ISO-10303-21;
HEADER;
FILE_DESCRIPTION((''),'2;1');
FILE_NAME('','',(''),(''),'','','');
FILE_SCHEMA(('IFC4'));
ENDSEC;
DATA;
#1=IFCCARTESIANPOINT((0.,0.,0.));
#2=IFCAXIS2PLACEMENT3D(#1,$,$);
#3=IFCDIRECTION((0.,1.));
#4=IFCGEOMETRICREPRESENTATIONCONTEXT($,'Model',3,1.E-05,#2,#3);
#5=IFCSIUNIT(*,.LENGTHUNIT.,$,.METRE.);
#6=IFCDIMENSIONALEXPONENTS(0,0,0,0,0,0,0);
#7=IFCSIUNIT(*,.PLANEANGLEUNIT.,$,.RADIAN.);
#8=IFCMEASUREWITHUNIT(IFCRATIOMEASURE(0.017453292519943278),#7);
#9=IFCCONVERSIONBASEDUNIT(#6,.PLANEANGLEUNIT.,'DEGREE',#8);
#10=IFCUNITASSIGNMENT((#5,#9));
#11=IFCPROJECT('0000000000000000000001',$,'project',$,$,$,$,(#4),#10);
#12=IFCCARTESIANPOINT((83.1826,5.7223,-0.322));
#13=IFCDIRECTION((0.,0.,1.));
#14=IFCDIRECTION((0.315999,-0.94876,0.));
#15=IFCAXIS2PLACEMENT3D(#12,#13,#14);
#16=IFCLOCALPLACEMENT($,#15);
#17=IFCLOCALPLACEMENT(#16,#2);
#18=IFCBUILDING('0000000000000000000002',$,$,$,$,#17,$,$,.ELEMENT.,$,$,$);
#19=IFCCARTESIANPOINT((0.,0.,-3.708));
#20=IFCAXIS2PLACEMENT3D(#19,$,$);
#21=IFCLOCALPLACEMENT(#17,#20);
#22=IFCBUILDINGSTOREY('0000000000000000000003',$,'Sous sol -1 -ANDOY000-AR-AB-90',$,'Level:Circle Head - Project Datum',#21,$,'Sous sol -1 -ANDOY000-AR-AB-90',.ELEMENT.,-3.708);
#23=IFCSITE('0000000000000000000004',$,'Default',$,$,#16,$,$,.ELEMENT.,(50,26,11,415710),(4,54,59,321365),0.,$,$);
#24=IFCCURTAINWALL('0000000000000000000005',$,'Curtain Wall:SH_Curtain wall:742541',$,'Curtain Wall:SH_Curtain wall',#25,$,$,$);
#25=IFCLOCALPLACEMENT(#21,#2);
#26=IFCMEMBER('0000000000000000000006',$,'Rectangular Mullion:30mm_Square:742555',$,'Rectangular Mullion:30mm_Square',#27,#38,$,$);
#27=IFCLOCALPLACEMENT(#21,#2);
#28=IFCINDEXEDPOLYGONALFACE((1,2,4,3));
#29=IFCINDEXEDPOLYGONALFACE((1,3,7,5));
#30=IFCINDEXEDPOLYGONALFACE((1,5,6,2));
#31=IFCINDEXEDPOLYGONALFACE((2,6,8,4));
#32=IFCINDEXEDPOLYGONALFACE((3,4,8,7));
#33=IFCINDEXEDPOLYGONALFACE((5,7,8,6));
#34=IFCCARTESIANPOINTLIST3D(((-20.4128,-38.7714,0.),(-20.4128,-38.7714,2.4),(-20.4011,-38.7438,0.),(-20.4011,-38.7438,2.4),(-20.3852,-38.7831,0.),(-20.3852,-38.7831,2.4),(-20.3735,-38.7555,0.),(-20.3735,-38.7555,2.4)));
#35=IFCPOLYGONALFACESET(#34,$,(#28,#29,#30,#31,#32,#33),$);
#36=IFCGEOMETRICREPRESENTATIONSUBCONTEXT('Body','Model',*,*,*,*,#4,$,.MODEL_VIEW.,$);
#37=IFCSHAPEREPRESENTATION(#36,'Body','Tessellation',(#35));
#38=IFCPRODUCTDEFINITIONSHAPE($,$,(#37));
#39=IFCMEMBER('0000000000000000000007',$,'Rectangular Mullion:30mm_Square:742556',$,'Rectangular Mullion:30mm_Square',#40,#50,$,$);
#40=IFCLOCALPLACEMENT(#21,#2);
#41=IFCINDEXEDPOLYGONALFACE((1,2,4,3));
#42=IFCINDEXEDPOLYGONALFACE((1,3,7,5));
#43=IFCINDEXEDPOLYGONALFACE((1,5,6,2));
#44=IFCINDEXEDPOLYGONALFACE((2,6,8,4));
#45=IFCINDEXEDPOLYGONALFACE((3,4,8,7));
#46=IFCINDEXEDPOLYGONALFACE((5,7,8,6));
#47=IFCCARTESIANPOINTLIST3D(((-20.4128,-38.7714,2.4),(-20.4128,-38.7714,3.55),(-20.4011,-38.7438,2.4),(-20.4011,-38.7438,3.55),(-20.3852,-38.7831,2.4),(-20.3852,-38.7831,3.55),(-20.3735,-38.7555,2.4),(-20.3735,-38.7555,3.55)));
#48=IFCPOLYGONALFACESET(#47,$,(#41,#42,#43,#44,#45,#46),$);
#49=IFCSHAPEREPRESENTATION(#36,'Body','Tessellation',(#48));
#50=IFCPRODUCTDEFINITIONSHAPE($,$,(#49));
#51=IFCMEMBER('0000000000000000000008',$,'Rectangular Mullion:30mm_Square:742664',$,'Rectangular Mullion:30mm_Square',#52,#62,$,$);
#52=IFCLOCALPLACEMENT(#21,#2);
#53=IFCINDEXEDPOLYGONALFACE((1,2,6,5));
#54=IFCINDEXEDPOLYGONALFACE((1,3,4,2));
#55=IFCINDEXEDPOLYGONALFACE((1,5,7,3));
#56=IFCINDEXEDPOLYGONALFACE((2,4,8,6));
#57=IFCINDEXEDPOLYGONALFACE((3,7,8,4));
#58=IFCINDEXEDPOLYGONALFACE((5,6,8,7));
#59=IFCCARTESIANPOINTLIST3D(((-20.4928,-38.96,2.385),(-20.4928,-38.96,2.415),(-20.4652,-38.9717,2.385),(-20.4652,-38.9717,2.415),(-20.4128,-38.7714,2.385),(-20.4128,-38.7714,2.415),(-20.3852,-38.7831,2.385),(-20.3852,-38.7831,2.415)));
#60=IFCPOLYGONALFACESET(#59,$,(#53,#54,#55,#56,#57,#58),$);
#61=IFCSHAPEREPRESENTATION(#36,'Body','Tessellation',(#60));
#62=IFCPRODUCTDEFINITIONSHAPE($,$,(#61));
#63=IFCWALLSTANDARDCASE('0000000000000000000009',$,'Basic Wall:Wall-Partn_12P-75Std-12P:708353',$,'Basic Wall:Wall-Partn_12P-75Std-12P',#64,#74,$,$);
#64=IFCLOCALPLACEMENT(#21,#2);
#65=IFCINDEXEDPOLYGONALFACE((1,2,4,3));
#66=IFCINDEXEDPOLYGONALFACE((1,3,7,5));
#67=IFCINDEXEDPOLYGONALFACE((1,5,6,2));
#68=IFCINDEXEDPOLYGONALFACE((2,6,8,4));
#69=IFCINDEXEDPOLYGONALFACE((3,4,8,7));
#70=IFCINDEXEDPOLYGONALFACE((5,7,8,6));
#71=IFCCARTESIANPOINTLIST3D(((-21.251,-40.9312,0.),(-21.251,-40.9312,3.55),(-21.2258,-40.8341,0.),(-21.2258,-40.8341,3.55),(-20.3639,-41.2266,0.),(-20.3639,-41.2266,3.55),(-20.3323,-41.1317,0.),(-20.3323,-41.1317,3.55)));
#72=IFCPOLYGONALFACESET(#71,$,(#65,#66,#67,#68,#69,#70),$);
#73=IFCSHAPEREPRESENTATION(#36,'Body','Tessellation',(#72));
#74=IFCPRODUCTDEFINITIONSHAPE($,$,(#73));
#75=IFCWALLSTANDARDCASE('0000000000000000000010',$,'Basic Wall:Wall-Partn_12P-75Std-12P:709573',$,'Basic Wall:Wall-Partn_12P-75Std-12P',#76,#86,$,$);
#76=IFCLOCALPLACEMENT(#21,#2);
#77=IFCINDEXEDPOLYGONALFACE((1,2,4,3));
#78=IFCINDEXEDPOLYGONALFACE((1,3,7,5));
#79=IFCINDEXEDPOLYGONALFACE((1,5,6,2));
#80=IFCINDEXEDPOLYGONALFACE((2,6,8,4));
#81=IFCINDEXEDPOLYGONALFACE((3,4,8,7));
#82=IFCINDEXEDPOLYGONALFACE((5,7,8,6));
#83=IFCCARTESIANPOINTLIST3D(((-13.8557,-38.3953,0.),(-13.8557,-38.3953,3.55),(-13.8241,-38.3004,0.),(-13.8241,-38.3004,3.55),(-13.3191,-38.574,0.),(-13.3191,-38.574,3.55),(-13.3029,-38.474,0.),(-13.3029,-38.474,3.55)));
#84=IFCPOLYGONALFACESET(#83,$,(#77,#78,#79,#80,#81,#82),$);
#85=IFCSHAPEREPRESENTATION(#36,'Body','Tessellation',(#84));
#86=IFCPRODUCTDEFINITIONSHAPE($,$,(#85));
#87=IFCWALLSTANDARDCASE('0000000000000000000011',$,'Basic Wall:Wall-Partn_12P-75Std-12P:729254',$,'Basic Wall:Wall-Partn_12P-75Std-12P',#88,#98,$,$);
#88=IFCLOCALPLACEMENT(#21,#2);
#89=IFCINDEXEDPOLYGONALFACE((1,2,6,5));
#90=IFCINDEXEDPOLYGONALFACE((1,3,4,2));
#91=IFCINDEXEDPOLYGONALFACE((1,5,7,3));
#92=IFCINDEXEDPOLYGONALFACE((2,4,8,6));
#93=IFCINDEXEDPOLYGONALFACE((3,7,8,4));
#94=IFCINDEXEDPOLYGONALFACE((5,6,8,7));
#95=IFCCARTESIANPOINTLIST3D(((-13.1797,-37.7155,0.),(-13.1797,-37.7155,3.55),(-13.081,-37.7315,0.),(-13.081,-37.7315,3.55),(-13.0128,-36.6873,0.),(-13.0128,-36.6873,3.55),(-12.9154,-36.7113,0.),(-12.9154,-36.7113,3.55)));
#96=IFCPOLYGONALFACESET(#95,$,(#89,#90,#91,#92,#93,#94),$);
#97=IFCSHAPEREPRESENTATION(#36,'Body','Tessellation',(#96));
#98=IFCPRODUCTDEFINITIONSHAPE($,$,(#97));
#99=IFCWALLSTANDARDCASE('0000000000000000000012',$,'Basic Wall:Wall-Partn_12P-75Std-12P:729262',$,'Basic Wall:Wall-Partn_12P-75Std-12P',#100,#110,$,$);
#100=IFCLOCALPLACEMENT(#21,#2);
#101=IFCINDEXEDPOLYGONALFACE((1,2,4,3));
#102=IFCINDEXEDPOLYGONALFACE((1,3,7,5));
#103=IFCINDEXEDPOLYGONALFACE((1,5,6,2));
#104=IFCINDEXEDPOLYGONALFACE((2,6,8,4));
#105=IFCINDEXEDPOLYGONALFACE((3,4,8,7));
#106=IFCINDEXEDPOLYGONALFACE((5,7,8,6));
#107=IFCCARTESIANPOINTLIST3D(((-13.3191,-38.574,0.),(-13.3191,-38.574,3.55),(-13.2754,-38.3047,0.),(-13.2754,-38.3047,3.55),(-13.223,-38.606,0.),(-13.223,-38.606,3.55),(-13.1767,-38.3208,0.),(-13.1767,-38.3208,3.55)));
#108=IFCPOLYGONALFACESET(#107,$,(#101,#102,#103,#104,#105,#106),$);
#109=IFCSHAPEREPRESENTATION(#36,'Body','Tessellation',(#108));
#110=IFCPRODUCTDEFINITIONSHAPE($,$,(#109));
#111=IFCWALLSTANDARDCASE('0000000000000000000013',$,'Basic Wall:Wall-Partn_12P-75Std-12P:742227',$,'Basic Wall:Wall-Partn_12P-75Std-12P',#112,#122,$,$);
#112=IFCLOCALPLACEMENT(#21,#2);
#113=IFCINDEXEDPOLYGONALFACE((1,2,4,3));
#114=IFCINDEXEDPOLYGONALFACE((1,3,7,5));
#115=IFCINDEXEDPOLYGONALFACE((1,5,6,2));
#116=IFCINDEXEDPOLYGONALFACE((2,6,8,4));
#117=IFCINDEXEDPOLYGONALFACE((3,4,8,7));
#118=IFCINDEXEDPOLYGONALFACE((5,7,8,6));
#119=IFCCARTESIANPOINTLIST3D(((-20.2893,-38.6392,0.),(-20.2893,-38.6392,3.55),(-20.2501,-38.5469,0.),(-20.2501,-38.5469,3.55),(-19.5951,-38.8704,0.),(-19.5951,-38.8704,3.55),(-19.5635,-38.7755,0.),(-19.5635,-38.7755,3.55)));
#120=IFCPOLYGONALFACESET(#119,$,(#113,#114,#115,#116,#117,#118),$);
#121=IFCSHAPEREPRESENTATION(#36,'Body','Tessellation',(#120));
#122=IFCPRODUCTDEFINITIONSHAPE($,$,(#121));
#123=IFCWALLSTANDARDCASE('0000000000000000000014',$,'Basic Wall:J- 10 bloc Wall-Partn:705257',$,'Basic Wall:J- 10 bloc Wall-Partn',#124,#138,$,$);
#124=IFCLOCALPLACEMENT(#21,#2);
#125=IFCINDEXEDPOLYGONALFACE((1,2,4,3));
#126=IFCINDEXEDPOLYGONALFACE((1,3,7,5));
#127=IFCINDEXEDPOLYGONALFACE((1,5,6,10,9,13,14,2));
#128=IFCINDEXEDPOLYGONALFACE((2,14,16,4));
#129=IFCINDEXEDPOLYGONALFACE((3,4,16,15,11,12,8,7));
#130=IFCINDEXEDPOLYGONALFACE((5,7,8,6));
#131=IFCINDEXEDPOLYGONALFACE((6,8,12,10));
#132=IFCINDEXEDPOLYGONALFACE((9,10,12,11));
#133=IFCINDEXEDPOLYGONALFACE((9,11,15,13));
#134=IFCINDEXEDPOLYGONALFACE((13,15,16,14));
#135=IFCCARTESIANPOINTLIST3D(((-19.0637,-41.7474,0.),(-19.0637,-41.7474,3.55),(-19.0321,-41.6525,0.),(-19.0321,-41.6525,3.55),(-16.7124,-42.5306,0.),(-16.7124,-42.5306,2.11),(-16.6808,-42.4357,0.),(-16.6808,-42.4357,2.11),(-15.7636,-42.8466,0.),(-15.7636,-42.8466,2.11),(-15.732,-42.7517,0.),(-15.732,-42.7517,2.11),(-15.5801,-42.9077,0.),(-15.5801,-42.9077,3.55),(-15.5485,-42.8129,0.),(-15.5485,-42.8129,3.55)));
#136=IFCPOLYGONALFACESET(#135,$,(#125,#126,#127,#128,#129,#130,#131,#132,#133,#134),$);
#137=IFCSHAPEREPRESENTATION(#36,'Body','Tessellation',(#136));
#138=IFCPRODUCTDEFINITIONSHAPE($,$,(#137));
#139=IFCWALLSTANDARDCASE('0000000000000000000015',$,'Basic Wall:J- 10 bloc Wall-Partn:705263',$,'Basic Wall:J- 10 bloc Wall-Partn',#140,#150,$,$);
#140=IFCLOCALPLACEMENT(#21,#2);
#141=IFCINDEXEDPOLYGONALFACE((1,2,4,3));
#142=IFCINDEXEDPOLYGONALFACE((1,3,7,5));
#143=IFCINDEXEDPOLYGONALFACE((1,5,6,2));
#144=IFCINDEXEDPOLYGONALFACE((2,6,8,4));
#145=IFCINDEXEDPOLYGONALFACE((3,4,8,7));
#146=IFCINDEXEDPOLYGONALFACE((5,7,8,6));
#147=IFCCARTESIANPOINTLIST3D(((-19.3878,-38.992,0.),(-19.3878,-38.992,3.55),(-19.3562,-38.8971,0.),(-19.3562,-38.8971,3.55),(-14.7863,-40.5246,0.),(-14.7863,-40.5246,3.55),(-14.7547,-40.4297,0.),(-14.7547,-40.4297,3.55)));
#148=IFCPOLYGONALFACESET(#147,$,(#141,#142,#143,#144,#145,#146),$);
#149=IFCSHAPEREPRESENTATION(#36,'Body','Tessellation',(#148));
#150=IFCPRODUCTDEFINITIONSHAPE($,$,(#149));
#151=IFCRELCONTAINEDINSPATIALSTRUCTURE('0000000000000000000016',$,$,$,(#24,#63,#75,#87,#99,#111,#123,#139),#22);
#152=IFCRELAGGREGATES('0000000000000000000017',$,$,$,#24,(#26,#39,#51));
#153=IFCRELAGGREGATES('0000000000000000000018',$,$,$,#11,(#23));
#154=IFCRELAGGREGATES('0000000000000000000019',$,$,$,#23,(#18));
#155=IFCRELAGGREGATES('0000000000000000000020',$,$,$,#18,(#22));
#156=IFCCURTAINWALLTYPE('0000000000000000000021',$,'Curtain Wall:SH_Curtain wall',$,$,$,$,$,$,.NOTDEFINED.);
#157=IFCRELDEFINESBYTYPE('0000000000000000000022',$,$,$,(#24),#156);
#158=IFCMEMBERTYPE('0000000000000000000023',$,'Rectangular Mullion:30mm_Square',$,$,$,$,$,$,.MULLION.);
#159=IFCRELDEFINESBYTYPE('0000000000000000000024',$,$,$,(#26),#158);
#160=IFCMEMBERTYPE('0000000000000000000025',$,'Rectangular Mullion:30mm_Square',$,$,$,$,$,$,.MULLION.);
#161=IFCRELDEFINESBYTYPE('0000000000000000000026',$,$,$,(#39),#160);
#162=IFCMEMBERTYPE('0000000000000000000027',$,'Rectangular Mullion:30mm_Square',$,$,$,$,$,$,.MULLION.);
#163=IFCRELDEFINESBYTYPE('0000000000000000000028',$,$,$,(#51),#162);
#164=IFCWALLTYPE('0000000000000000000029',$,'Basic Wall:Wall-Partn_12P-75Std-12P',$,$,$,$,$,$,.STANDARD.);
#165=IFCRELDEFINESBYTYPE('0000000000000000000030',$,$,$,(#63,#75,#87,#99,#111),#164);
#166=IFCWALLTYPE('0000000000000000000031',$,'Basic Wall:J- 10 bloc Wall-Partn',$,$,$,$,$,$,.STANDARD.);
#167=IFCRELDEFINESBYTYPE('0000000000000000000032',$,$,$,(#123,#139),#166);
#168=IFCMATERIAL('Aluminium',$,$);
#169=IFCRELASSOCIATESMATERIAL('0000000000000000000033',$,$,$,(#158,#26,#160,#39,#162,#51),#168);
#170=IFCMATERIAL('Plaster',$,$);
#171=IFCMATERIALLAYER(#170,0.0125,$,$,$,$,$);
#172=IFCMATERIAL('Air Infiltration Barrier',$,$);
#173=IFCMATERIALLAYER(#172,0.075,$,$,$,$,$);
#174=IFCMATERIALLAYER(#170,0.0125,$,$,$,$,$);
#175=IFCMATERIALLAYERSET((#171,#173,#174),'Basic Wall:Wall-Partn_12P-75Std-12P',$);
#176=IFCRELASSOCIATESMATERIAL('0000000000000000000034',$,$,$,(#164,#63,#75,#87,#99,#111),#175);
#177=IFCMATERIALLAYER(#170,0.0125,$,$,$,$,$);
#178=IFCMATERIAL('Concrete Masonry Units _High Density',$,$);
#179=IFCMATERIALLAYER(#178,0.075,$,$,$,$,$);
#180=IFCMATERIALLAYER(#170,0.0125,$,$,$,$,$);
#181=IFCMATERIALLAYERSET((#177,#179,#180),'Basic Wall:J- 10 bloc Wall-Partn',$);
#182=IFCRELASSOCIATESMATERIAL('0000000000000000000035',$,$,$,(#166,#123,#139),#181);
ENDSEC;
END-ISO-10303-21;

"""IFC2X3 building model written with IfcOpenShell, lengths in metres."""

from ifc_helpers import new_model, entity, si_unit, converted_unit, direction, frame, frame_2d, origin, origin_2d_with_axis, place, context, subcontext, project, spatial, polyline, rectangle, outline, extrude, clip, bounded_halfspace, source, transform, mapped, material, layer, layer_set, layer_usage, type_object, type_shapes, element, aggregate, save


model = new_model("IFC2X3")

# Units and contexts
model_context = context("Model", 3, precision=1e-05, world=origin(), true_north=direction((0.0, 1.0)))
body_context = subcontext(model_context, "Body", "Model", "MODEL_VIEW")
ifc_project = project(units=[si_unit("LENGTHUNIT", "METRE"), converted_unit("PLANEANGLEUNIT", "DEGREE", entity("IfcRatioMeasure", 0.017453292519943278), si_unit("PLANEANGLEUNIT", "RADIAN"), dimensions=[0, 0, 0, 0, 0, 0, 0])], contexts=[model_context])

# Site, building, storey
site_placement = place(None, frame((83.1826, 5.7223, -0.322), z_axis=(0.0, 0.0, 1.0), x_axis=(0.315999, -0.94876, 0.0)))
site = spatial("IfcSite", under=ifc_project, at=site_placement, Name="Default", CompositionType="ELEMENT", RefLatitude=(50, 26, 11, 415710), RefLongitude=(4, 54, 59, 321365), RefElevation=0.0)
building_placement = place(site_placement, origin())
building = spatial("IfcBuilding", under=site, at=building_placement, CompositionType="ELEMENT")
storey_placement = place(building_placement, frame((0.0, 0.0, -3.708)))
storey = spatial("IfcBuildingStorey", under=building, at=storey_placement, Name="Sous sol -1 -ANDOY000-AR-AB-90", ObjectType="Level:Circle Head - Project Datum", LongName="Sous sol -1 -ANDOY000-AR-AB-90", CompositionType="ELEMENT", Elevation=-3.708)

# Curtain wall, members
curtain_wall_type = type_object("IfcCurtainWallType", Name="Curtain Wall:SH_Curtain wall", PredefinedType="NOTDEFINED")
curtain_wall_placement = place(storey_placement, frame((0.0, 0.0, 3.708)))
curtain_wall = element("IfcCurtainWall", 1, at=curtain_wall_placement, inside=storey, type_object=curtain_wall_type, Name="Curtain Wall:SH_Curtain wall:742541", ObjectType="Curtain Wall:SH_Curtain wall")
ifc_material_1 = material(Name="Aluminium")
member_type_1 = type_object("IfcMemberType", Name="Rectangular Mullion:30mm_Square", PredefinedType="MULLION", material=ifc_material_1)
shared_shape_1 = source(origin(), body_context, "Body", "SweptSolid", [
    extrude(rectangle(XDim=0.03, YDim=0.03, at=origin_2d_with_axis()), frame((-0.015, 0.0, -2.4), z_axis=(0.0, 0.0, 1.0), x_axis=(0.0, -1.0, 0.0)), (0.0, 0.0, 1.0), 2.4),
])
type_shapes(member_type_1, [shared_shape_1])
member_1_placement = place(curtain_wall_placement, frame((-20.3873, -38.7497, -3.708), z_axis=(0.0, 0.0, -1.0), x_axis=(0.390731, 0.920505, 0.0)))
member_1 = element("IfcMember", 2, at=member_1_placement, type_object=member_type_1, material=ifc_material_1, Name="Rectangular Mullion:30mm_Square:742555", ObjectType="Rectangular Mullion:30mm_Square", context=body_context, shape_type="MappedRepresentation", body=[
    mapped(shared_shape_1, transform((0.0, 0.0, 0.0), scale=1.0)),
])
member_type_2 = type_object("IfcMemberType", Name="Rectangular Mullion:30mm_Square", PredefinedType="MULLION", material=ifc_material_1)
shared_shape_2 = source(origin(), body_context, "Body", "SweptSolid", [
    extrude(rectangle(XDim=0.03, YDim=0.03, at=origin_2d_with_axis()), frame((-0.015, 0.0, -1.15), z_axis=(0.0, 0.0, 1.0), x_axis=(0.0, -1.0, 0.0)), (0.0, 0.0, 1.0), 1.15),
])
type_shapes(member_type_2, [shared_shape_2])
member_2_placement = place(curtain_wall_placement, frame((-20.3873, -38.7497, -1.308), z_axis=(0.0, 0.0, -1.0), x_axis=(0.390731, 0.920505, 0.0)))
member_2 = element("IfcMember", 3, at=member_2_placement, type_object=member_type_2, material=ifc_material_1, Name="Rectangular Mullion:30mm_Square:742556", ObjectType="Rectangular Mullion:30mm_Square", context=body_context, shape_type="MappedRepresentation", body=[
    mapped(shared_shape_2, transform((0.0, 0.0, 0.0), scale=1.0)),
])
member_type_3 = type_object("IfcMemberType", Name="Rectangular Mullion:30mm_Square", PredefinedType="MULLION", material=ifc_material_1)
shared_shape_3 = source(origin(), body_context, "Body", "SweptSolid", [
    extrude(rectangle(XDim=0.03, YDim=0.03, at=origin_2d_with_axis()), frame((0.0, 0.0, -0.2048), z_axis=(0.0, 0.0, 1.0), x_axis=(0.0, -1.0, 0.0)), (0.0, 0.0, 1.0), 0.2048),
])
type_shapes(member_type_3, [shared_shape_3])
member_3_placement = place(curtain_wall_placement, frame((-20.399, -38.7773, -1.308), z_axis=(0.390731, 0.920505, 0.0), x_axis=(0.0, 0.0, 1.0)))
member_3 = element("IfcMember", 4, at=member_3_placement, type_object=member_type_3, material=ifc_material_1, Name="Rectangular Mullion:30mm_Square:742664", ObjectType="Rectangular Mullion:30mm_Square", context=body_context, shape_type="MappedRepresentation", body=[
    mapped(shared_shape_3, transform((0.0, 0.0, 0.0), scale=1.0)),
])
aggregate(curtain_wall, [member_1, member_2, member_3])

# Walls
ifc_material_2 = material(Name="Plaster")
ifc_layer_1 = layer(ifc_material_2, 0.0125)
ifc_material_3 = material(Name="Air Infiltration Barrier")
ifc_layer_2 = layer(ifc_material_3, 0.075)
ifc_layer_3 = layer(ifc_material_2, 0.0125)
ifc_layer_set_1 = layer_set([ifc_layer_1, ifc_layer_2, ifc_layer_3], Name="Basic Wall:Wall-Partn_12P-75Std-12P")
ifc_layer_usage_1 = layer_usage(ifc_layer_set_1, "AXIS2", "NEGATIVE", 0.05)
wall_type_1 = type_object("IfcWallType", Name="Basic Wall:Wall-Partn_12P-75Std-12P", PredefinedType="STANDARD", material=ifc_layer_set_1)
wall_1_placement = place(storey_placement, frame((-20.3481, -41.1792, 0.0), z_axis=(0.0, 0.0, 1.0), x_axis=(-0.948759, 0.316, 0.0)))
element("IfcWallStandardCase", 5, at=wall_1_placement, inside=storey, type_object=wall_type_1, material=ifc_layer_usage_1, Name="Basic Wall:Wall-Partn_12P-75Std-12P:708353", ObjectType="Basic Wall:Wall-Partn_12P-75Std-12P", context=body_context, shape_type="Clipping", body=[
    clip(extrude(outline(polyline([(0.9418, -0.05), (0.9349, 0.05), (0.0, 0.05), (0.0, -0.05), (0.9343, -0.05), (0.9418, -0.05)])), origin(), (0.0, 0.0, 1.0), 3.55), bounded_halfspace(frame((0.0, -0.05, 3.55), z_axis=(0.0, 0.0, -1.0), x_axis=(-1.0, 0.0, 0.0)), True, frame((0.0, -0.05, 3.55)), polyline([(0.0, 0.0), (0.9343, 0.0), (0.9418, 0.0), (0.9349, 0.1), (0.0, 0.1), (0.0, 0.0)]))),
])
wall_2_placement = place(storey_placement, frame((-13.8399, -38.3479, 0.0), z_axis=(0.0, 0.0, 1.0), x_axis=(0.948759, -0.316, 0.0)))
element("IfcWallStandardCase", 6, at=wall_2_placement, inside=storey, type_object=wall_type_1, material=ifc_layer_usage_1, Name="Basic Wall:Wall-Partn_12P-75Std-12P:709573", ObjectType="Basic Wall:Wall-Partn_12P-75Std-12P", context=body_context, shape_type="Clipping", body=[
    clip(extrude(outline(polyline([(0.5655, -0.05), (0.5493, 0.05), (0.0, 0.05), (0.0, -0.05), (0.5655, -0.05)])), origin(), (0.0, 0.0, 1.0), 3.55), bounded_halfspace(frame((0.0, -0.05, 3.55), z_axis=(0.0, 0.0, -1.0), x_axis=(1.0, 0.0, 0.0)), True, frame((0.0, -0.05, 3.55)), polyline([(0.0, 0.0), (0.5655, 0.0), (0.5493, 0.1), (0.0, 0.1), (0.0, 0.0)]))),
])
wall_3_placement = place(storey_placement, frame((-13.1304, -37.7235, 0.0), z_axis=(0.0, 0.0, 1.0), x_axis=(0.160241, 0.987078, 0.0)))
element("IfcWallStandardCase", 7, at=wall_3_placement, inside=storey, type_object=wall_type_1, material=ifc_layer_usage_1, Name="Basic Wall:Wall-Partn_12P-75Std-12P:729254", ObjectType="Basic Wall:Wall-Partn_12P-75Std-12P", context=body_context, shape_type="Clipping", body=[
    clip(extrude(outline(polyline([(1.0336, -0.05), (1.0416, 0.05), (0.0, 0.05), (0.0, -0.05), (1.0336, -0.05)])), origin(), (0.0, 0.0, 1.0), 3.55), bounded_halfspace(frame((0.0, -0.05, 3.55), z_axis=(0.0, 0.0, -1.0), x_axis=(-0.159887, -0.987135, 0.0)), True, frame((0.0, -0.05, 3.55)), polyline([(0.0, 0.0), (1.0336, 0.0), (1.0416, 0.1), (0.0, 0.1), (0.0, 0.0)]))),
])
wall_4_placement = place(storey_placement, frame((-13.2724, -38.598, 0.0), z_axis=(0.0, 0.0, 1.0), x_axis=(0.160241, 0.987078, 0.0)))
element("IfcWallStandardCase", 8, at=wall_4_placement, inside=storey, type_object=wall_type_1, material=ifc_layer_usage_1, Name="Basic Wall:Wall-Partn_12P-75Std-12P:729262", ObjectType="Basic Wall:Wall-Partn_12P-75Std-12P", context=body_context, shape_type="Clipping", body=[
    clip(extrude(outline(polyline([(0.289, -0.05), (0.289, 0.05), (0.1175, 0.05), (0.0162, 0.05), (0.0, -0.05), (0.289, -0.05)])), origin(), (0.0, 0.0, 1.0), 3.55), bounded_halfspace(frame((0.0, -0.05, 3.55), z_axis=(0.0, 0.0, -1.0), x_axis=(-0.159887, -0.987135, 0.0)), True, frame((0.0, -0.05, 3.55)), polyline([(0.0, 0.0), (0.289, 0.0), (0.289, 0.1), (0.1175, 0.1), (0.0162, 0.1), (0.0, 0.0)]))),
])
wall_5_placement = place(storey_placement, frame((-19.5793, -38.823, 0.0), z_axis=(0.0, 0.0, 1.0), x_axis=(-0.948772, 0.315961, 0.0)))
element("IfcWallStandardCase", 9, at=wall_5_placement, inside=storey, type_object=wall_type_1, material=ifc_layer_usage_1, Name="Basic Wall:Wall-Partn_12P-75Std-12P:742227", ObjectType="Basic Wall:Wall-Partn_12P-75Std-12P", context=body_context, shape_type="Clipping", body=[
    clip(extrude(outline(polyline([(0.7237, -0.05), (0.7317, 0.05), (0.7287, 0.05), (0.0, 0.05), (0.0, -0.05), (0.7237, -0.05)])), origin(), (0.0, 0.0, 1.0), 3.55), bounded_halfspace(frame((0.0, -0.05, 3.55), z_axis=(0.0, 0.0, -1.0), x_axis=(-1.0, 0.000041, 0.0)), True, frame((0.0, -0.05, 3.55)), polyline([(0.0, 0.0), (0.7237, 0.0), (0.7317, 0.1), (0.7287, 0.1), (0.0, 0.1), (0.0, 0.0)]))),
])

# Wall, opening
ifc_layer_4 = layer(ifc_material_2, 0.0125)
ifc_material_4 = material(Name="Concrete Masonry Units _High Density")
ifc_layer_5 = layer(ifc_material_4, 0.075)
ifc_layer_6 = layer(ifc_material_2, 0.0125)
ifc_layer_set_2 = layer_set([ifc_layer_4, ifc_layer_5, ifc_layer_6], Name="Basic Wall:J- 10 bloc Wall-Partn")
ifc_layer_usage_2 = layer_usage(ifc_layer_set_2, "AXIS2", "NEGATIVE", 0.05)
wall_type_2 = type_object("IfcWallType", Name="Basic Wall:J- 10 bloc Wall-Partn", PredefinedType="STANDARD", material=ifc_layer_set_2)
wall_6_placement = place(storey_placement, frame((-15.5643, -42.8603, 0.0), z_axis=(0.0, 0.0, 1.0), x_axis=(-0.948755, 0.316014, 0.0)))
wall_6 = element("IfcWallStandardCase", 10, at=wall_6_placement, inside=storey, type_object=wall_type_2, material=ifc_layer_usage_2, Name="Basic Wall:J- 10 bloc Wall-Partn:705257", ObjectType="Basic Wall:J- 10 bloc Wall-Partn", context=body_context, shape_type="Clipping", body=[
    clip(extrude(rectangle(XDim=3.6717, YDim=0.1, at=frame_2d((1.8359, 0.0), x_axis=(1.0, 0.0))), origin(), (0.0, 0.0, 1.0), 3.55), bounded_halfspace(frame((0.0, -0.05, 3.55), z_axis=(0.0, 0.0, -1.0), x_axis=(-1.0, -0.000014, 0.0)), True, frame((0.0, -0.05, 3.55)), polyline([(0.0, 0.0), (3.6717, 0.0), (3.6717, 0.1), (1.2051, 0.1), (1.1051, 0.1), (0.0, 0.1), (0.0, 0.0)]))),
])
opening_placement = place(wall_6_placement, frame((1.1934, 0.05, 0.0)))
element("IfcOpeningElement", 11, at=opening_placement, cuts=wall_6, ObjectType="Opening", context=body_context, shape_type="SweptSolid", body=[
    extrude(rectangle(XDim=2.11, YDim=1.0, at=frame_2d((1.055, 0.5), x_axis=(1.0, 0.0))), frame((0.0, 0.0, 0.0), z_axis=(0.0, -1.0, 0.0), x_axis=(0.0, 0.0, 1.0)), (0.0, 0.0, 1.0), 0.1),
])

# Wall
wall_7_placement = place(storey_placement, frame((-19.372, -38.9446, 0.0), z_axis=(0.0, 0.0, 1.0), x_axis=(0.948759, -0.316, 0.0)))
element("IfcWallStandardCase", 12, at=wall_7_placement, inside=storey, type_object=wall_type_2, material=ifc_layer_usage_2, Name="Basic Wall:J- 10 bloc Wall-Partn:705263", ObjectType="Basic Wall:J- 10 bloc Wall-Partn", context=body_context, shape_type="Clipping", body=[
    clip(extrude(rectangle(XDim=4.85, YDim=0.1, at=frame_2d((2.425, 0.0), x_axis=(-1.0, 0.0))), origin(), (0.0, 0.0, 1.0), 3.55), bounded_halfspace(frame((0.0, -0.05, 3.55), z_axis=(0.0, 0.0, -1.0), x_axis=(1.0, 0.0, 0.0)), True, frame((0.0, -0.05, 3.55)), polyline([(0.0, 0.0), (4.85, 0.0), (4.85, 0.1), (0.0, 0.1), (0.0, 0.0)]))),
])

save(model, "model.ifc")
